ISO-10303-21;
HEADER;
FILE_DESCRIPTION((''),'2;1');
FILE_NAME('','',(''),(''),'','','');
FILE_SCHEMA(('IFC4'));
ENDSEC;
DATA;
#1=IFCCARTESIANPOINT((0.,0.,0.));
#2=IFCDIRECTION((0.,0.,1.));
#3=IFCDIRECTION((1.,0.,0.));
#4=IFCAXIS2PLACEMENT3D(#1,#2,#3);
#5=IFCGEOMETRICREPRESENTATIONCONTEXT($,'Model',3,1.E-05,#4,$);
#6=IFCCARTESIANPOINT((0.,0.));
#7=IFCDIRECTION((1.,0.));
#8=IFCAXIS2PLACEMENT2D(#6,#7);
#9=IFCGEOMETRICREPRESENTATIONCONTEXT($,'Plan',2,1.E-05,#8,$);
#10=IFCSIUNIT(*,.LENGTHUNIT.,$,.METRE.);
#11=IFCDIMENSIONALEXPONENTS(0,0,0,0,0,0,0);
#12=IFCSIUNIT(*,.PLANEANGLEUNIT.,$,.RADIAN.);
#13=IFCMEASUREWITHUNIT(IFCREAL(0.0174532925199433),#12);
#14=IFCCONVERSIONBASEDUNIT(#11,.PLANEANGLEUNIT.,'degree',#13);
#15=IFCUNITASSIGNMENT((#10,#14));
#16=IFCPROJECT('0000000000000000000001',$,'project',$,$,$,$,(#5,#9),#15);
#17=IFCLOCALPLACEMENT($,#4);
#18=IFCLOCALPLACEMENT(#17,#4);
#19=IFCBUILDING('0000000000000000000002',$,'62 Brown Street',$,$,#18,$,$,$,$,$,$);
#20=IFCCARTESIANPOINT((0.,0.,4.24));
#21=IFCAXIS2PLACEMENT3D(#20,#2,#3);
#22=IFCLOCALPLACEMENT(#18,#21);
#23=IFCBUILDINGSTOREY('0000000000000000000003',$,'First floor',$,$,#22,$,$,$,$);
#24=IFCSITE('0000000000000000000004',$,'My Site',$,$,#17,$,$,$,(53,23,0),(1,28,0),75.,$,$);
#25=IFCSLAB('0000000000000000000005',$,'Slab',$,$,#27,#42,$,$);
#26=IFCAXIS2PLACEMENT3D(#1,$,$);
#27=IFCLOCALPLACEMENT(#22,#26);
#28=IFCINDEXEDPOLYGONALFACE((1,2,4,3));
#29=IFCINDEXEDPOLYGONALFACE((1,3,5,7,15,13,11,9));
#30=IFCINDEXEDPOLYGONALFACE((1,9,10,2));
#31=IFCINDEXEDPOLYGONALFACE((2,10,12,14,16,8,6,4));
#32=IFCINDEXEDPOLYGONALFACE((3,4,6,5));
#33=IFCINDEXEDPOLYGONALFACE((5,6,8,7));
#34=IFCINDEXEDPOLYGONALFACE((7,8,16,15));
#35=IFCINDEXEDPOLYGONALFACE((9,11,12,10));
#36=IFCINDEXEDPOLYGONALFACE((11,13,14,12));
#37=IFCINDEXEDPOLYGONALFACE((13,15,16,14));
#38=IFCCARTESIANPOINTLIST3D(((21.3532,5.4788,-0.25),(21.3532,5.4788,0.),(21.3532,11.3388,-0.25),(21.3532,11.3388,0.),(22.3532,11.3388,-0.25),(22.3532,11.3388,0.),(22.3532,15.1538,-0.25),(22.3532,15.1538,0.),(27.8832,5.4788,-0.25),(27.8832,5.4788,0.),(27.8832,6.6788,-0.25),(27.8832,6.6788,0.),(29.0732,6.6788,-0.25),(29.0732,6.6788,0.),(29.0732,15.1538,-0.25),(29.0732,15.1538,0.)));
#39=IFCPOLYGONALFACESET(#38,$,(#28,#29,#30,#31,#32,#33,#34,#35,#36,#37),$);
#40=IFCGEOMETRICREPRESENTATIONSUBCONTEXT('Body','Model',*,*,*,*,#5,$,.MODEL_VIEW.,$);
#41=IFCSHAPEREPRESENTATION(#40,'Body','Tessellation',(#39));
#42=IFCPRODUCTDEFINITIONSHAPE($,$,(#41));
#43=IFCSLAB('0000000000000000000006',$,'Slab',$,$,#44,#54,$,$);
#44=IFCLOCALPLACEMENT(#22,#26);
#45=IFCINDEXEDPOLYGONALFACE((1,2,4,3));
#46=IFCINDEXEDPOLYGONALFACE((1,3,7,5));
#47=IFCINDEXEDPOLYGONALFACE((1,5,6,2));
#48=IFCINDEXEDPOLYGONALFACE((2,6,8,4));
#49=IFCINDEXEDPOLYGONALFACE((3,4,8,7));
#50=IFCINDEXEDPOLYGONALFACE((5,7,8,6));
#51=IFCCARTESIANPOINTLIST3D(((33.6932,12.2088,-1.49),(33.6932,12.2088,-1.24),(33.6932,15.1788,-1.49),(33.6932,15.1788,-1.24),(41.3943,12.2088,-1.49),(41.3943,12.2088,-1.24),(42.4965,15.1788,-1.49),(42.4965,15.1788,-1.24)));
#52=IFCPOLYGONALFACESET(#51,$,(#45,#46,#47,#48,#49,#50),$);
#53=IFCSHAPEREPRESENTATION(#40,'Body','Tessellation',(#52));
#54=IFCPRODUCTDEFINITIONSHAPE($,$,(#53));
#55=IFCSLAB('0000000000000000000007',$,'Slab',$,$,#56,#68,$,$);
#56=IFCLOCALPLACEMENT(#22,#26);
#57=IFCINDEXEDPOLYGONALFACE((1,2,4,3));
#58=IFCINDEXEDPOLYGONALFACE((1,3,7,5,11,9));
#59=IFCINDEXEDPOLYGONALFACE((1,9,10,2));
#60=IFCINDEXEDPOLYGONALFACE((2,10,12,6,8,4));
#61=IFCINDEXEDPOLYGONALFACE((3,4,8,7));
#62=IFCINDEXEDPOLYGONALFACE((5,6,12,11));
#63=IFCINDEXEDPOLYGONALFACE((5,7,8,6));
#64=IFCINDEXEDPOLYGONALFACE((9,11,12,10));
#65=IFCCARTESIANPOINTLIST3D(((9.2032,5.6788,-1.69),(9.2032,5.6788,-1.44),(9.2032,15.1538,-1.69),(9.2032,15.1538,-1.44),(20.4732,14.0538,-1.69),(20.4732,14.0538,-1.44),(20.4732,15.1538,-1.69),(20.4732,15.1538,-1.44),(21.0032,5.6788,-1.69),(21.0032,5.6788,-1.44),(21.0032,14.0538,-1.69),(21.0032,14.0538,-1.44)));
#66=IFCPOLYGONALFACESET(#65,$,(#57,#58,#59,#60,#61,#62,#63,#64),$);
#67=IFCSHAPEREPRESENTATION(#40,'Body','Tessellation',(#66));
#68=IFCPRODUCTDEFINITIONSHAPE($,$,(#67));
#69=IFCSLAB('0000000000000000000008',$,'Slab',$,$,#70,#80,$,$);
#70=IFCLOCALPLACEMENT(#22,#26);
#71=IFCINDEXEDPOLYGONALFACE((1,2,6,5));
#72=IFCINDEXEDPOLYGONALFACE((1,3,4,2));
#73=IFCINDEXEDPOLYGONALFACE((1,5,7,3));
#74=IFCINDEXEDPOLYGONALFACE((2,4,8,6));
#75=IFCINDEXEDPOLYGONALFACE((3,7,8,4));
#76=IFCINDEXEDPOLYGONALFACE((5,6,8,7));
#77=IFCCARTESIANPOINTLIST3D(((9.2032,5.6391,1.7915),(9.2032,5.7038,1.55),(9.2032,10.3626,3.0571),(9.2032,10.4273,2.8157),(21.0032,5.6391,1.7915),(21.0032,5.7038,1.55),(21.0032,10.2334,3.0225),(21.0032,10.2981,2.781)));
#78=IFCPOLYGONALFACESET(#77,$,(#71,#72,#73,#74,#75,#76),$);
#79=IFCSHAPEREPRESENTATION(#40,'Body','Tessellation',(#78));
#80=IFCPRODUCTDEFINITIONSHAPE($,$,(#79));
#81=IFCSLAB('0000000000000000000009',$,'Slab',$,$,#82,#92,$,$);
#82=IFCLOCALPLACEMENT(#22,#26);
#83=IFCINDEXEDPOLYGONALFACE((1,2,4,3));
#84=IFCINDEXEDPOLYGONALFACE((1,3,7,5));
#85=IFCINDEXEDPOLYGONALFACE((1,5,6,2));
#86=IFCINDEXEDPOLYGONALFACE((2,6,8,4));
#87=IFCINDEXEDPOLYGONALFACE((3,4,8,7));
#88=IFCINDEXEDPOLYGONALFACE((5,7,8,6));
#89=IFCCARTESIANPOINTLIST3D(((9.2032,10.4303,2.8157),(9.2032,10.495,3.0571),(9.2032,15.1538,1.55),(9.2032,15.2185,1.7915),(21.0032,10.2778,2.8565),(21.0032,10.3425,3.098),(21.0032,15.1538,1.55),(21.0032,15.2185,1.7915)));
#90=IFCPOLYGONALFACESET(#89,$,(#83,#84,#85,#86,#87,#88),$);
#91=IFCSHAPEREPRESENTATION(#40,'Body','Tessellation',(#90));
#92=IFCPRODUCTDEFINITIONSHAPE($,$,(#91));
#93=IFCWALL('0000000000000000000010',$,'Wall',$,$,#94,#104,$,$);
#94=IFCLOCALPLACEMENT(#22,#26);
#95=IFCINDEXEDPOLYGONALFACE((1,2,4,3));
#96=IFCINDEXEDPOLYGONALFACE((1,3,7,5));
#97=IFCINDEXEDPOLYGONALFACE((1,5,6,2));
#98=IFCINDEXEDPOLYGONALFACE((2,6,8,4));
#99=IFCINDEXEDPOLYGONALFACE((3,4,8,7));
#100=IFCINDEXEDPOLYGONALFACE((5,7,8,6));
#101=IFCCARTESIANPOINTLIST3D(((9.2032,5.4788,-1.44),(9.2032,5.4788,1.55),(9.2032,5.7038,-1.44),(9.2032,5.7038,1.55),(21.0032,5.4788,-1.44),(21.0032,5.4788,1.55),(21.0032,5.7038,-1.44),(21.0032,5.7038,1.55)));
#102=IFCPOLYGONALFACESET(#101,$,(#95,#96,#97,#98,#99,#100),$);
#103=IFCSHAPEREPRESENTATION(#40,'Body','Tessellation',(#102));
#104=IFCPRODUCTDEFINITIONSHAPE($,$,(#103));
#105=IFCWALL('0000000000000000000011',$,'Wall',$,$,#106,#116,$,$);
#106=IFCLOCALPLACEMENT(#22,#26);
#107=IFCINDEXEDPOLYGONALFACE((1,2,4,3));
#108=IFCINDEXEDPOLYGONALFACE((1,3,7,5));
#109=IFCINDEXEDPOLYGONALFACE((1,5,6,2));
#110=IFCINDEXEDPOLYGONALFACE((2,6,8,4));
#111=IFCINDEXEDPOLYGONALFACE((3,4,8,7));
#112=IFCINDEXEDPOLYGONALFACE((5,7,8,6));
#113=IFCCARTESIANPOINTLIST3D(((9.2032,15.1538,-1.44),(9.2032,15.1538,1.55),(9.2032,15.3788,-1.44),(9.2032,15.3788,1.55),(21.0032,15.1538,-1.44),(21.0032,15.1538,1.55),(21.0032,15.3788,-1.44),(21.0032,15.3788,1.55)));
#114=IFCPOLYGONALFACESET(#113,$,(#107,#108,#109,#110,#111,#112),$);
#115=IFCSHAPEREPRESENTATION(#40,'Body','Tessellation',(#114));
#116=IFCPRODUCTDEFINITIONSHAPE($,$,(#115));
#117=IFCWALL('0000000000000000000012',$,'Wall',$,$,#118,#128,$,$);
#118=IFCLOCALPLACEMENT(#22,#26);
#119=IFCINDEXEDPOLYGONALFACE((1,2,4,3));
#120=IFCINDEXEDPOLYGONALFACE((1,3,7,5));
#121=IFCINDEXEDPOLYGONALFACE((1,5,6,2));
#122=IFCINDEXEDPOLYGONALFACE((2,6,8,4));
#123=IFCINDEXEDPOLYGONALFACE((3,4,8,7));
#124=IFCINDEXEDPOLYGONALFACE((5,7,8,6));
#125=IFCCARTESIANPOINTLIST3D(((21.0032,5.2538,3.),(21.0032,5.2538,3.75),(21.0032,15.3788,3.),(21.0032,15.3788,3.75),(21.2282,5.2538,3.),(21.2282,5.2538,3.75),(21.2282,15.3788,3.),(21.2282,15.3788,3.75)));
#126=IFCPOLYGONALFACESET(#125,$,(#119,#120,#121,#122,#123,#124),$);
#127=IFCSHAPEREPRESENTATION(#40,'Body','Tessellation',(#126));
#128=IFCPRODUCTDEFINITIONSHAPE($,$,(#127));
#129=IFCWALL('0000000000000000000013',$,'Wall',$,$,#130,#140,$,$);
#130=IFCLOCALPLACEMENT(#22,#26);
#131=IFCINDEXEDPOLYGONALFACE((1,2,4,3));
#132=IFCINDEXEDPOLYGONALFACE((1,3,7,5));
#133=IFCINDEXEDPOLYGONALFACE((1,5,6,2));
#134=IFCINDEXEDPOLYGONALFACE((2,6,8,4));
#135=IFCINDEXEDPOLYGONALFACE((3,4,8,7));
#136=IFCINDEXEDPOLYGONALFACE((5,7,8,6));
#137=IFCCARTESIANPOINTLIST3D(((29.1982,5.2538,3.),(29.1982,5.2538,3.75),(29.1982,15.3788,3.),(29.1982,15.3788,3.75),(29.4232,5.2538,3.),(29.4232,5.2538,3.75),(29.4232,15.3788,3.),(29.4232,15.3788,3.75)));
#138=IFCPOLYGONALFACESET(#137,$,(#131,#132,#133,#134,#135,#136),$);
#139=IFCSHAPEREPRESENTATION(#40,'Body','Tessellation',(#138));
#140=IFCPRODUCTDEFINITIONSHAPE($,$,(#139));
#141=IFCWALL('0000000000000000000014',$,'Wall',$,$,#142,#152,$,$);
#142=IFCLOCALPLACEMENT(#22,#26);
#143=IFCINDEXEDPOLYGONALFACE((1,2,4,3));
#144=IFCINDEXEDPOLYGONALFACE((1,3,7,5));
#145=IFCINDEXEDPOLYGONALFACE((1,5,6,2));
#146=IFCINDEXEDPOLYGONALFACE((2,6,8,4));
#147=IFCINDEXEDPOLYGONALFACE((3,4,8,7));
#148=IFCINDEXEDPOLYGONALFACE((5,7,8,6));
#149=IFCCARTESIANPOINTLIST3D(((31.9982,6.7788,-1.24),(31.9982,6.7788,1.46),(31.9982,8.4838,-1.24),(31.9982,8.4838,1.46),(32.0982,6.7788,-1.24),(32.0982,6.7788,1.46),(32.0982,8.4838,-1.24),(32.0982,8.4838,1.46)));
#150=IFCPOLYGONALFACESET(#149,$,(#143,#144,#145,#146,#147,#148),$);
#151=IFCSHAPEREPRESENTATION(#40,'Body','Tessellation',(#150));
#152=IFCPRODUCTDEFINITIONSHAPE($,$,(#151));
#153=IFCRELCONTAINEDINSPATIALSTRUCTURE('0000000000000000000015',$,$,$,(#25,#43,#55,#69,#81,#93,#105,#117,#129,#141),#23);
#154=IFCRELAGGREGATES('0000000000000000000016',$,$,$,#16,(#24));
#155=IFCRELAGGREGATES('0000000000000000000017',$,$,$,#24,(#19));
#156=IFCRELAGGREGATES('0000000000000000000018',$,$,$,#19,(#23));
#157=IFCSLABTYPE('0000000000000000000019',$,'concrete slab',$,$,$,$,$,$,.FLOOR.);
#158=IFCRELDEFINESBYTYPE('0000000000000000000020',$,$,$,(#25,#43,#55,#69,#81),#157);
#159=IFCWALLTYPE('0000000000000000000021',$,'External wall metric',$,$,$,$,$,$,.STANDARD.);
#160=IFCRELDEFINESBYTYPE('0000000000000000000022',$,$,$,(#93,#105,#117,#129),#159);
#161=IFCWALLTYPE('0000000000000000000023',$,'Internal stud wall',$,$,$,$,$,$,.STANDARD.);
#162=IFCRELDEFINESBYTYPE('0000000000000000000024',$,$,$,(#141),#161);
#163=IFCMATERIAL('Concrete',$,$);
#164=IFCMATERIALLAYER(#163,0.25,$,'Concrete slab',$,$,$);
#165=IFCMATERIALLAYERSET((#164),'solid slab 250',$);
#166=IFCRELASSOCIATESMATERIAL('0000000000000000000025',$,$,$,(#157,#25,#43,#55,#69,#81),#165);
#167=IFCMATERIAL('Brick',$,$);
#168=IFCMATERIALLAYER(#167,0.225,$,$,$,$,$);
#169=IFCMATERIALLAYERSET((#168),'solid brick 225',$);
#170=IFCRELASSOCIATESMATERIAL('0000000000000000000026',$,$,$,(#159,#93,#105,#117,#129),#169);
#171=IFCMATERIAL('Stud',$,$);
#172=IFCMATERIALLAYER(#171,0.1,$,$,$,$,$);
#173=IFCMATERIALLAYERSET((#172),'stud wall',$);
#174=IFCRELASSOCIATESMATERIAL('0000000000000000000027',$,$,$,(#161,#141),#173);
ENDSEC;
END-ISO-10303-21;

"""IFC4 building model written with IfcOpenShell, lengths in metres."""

from ifc_helpers import new_model, entity, si_unit, converted_unit, frame, origin_with_axes, origin_2d_with_axis, place, context, subcontext, project, spatial, line, indexed_curve, outline, extrude, material, layer, layer_set, layer_usage, type_object, element, save


model = new_model("IFC4")

# Units and contexts
model_context = context("Model", 3, precision=1e-05, world=origin_with_axes())
plan_context = context("Plan", 2, precision=1e-05, world=origin_2d_with_axis())
body_context_1 = subcontext(model_context, "Body", "Model", "MODEL_VIEW")
ifc_project = project(units=[si_unit("LENGTHUNIT", "METRE"), converted_unit("PLANEANGLEUNIT", "degree", entity("IfcReal", 0.0174532925199433), si_unit("PLANEANGLEUNIT", "RADIAN"), dimensions=[0, 0, 0, 0, 0, 0, 0])], contexts=[model_context, plan_context])

# Site, building, storey
site_placement = place(None, origin_with_axes())
site = spatial("IfcSite", under=ifc_project, at=site_placement, Name="My Site", RefLatitude=(53, 23, 0), RefLongitude=(1, 28, 0), RefElevation=75.0)
building_placement = place(site_placement, origin_with_axes())
building = spatial("IfcBuilding", under=site, at=building_placement, Name="62 Brown Street")
storey_placement = place(building_placement, frame((0.0, 0.0, 4.24), z_axis=(0.0, 0.0, 1.0), x_axis=(1.0, 0.0, 0.0)))
storey = spatial("IfcBuildingStorey", under=building, at=storey_placement, Name="First floor")

# Slabs
ifc_material_1 = material(Name="Concrete")
ifc_layer_1 = layer(ifc_material_1, 0.25, Name="Concrete slab")
ifc_layer_set_1 = layer_set([ifc_layer_1], Name="solid slab 250")
ifc_layer_usage_1 = layer_usage(ifc_layer_set_1, "AXIS3", "POSITIVE", 0.0)
slab_type = type_object("IfcSlabType", Name="concrete slab", PredefinedType="FLOOR", material=ifc_layer_set_1)
slab_1_placement = place(storey_placement, frame((21.3532, 5.4788, -0.25), z_axis=(0.0, 0.0, 1.0), x_axis=(1.0, 0.0, 0.0)))
element("IfcSlab", 1, at=slab_1_placement, inside=storey, type_object=slab_type, material=ifc_layer_usage_1, Name="Slab", context=body_context_1, shape_type="SweptSolid", body=[
    extrude(outline(indexed_curve([(0.0, 5.86), (0.0, 0.0), (6.53, 0.0), (6.53, 1.2), (7.72, 1.2), (7.72, 9.675), (1.0, 9.675), (1.0, 5.86)], segments=[line(3, 2), line(2, 1), line(1, 8), line(8, 7), line(7, 6), line(6, 5), line(5, 4), line(4, 3)], self_intersect=False)), None, (0.0, 0.0, 1.0), 0.25),
])
ifc_layer_usage_2 = layer_usage(ifc_layer_set_1, "AXIS3", "POSITIVE", 0.0)
slab_2_placement = place(storey_placement, frame((33.6932, 12.2088, -1.49), z_axis=(0.0, 0.0, 1.0), x_axis=(1.0, 0.0, 0.0)))
element("IfcSlab", 2, at=slab_2_placement, inside=storey, type_object=slab_type, material=ifc_layer_usage_2, Name="Slab", context=body_context_1, shape_type="SweptSolid", body=[
    extrude(outline(indexed_curve([(8.8033, 2.97), (7.7011, 0.0), (0.0, 0.0), (0.0, 2.97)], segments=[line(4, 1), line(1, 2), line(2, 3), line(3, 4)], self_intersect=False)), None, (0.0, 0.0, 1.0), 0.25),
])
ifc_layer_usage_3 = layer_usage(ifc_layer_set_1, "AXIS3", "POSITIVE", 0.0)
slab_3_placement = place(storey_placement, frame((9.2032, 5.6788, -1.69), z_axis=(0.0, 0.0, 1.0), x_axis=(1.0, 0.0, 0.0)))
element("IfcSlab", 3, at=slab_3_placement, inside=storey, type_object=slab_type, material=ifc_layer_usage_3, Name="Slab", context=body_context_1, shape_type="SweptSolid", body=[
    extrude(outline(indexed_curve([(11.27, 9.475), (11.8, 0.0), (0.0, 0.0), (0.0, 9.475), (11.8, 8.375), (11.27, 8.375)], segments=[line(6, 1), line(1, 4), line(4, 3), line(3, 2), line(2, 5), line(5, 6)], self_intersect=False)), None, (0.0, 0.0, 1.0), 0.25),
])
ifc_layer_usage_4 = layer_usage(ifc_layer_set_1, "AXIS3", "POSITIVE", 0.0)
slab_4_placement = place(storey_placement, frame((9.2032, 5.7038, 1.55), z_axis=(0.0, -0.258819, 0.965926), x_axis=(1.0, 0.0, 0.0)))
element("IfcSlab", 4, at=slab_4_placement, inside=storey, type_object=slab_type, material=ifc_layer_usage_4, Name="Slab", context=body_context_1, shape_type="SweptSolid", body=[
    extrude(outline(indexed_curve([(0.0, 4.8901), (0.0, 0.0), (11.8, 0.0), (11.8, 4.7563)], segments=[line(3, 2), line(2, 1), line(1, 4), line(4, 3)], self_intersect=False)), None, (0.0, 0.0, 1.0), 0.25),
])
ifc_layer_usage_5 = layer_usage(ifc_layer_set_1, "AXIS3", "POSITIVE", 0.0)
slab_5_placement = place(storey_placement, frame((21.0032, 15.1538, 1.55), z_axis=(0.0, 0.258819, 0.965926), x_axis=(-1.0, 0.0, 0.0)))
element("IfcSlab", 5, at=slab_5_placement, inside=storey, type_object=slab_type, material=ifc_layer_usage_5, Name="Slab", context=body_context_1, shape_type="SweptSolid", body=[
    extrude(outline(indexed_curve([(0.0, 0.0), (11.8, 0.0), (11.8, 4.8901), (0.0, 5.048)], segments=[line(4, 1), line(1, 2), line(2, 3), line(3, 4)], self_intersect=False)), None, (0.0, 0.0, 1.0), 0.25),
])

# Walls
ifc_material_2 = material(Name="Brick")
ifc_layer_2 = layer(ifc_material_2, 0.225)
ifc_layer_set_2 = layer_set([ifc_layer_2], Name="solid brick 225")
ifc_layer_usage_6 = layer_usage(ifc_layer_set_2, "AXIS2", "POSITIVE", 0.0)
wall_type_1 = type_object("IfcWallType", Name="External wall metric", PredefinedType="STANDARD", material=ifc_layer_set_2)
wall_1_placement = place(storey_placement, frame((9.2032, 5.4788, -1.44), z_axis=(0.0, 0.0, 1.0), x_axis=(1.0, 0.0, 0.0)))
element("IfcWall", 6, at=wall_1_placement, inside=storey, type_object=wall_type_1, material=ifc_layer_usage_6, Name="Wall", context=body_context_1, shape_type="SweptSolid", body=[
    extrude(outline(indexed_curve([(0.0, 0.0), (0.0, 0.225), (11.8, 0.225), (11.8, 0.0), (0.0, 0.0)], self_intersect=False)), origin_with_axes(), (0.0, 0.0, 1.0), 2.99),
])
ifc_layer_usage_7 = layer_usage(ifc_layer_set_2, "AXIS2", "POSITIVE", 0.0)
wall_2_placement = place(storey_placement, frame((21.0032, 15.3788, -1.44), z_axis=(0.0, 0.0, 1.0), x_axis=(-1.0, 0.0, 0.0)))
element("IfcWall", 7, at=wall_2_placement, inside=storey, type_object=wall_type_1, material=ifc_layer_usage_7, Name="Wall", context=body_context_1, shape_type="SweptSolid", body=[
    extrude(outline(indexed_curve([(0.0, 0.0), (0.0, 0.225), (11.8, 0.225), (11.8, 0.0), (0.0, 0.0)], self_intersect=False)), origin_with_axes(), (0.0, 0.0, 1.0), 2.99),
])
ifc_layer_usage_8 = layer_usage(ifc_layer_set_2, "AXIS2", "POSITIVE", 0.0)
wall_3_placement = place(storey_placement, frame((21.0032, 15.3788, 3.0), z_axis=(0.0, 0.0, 1.0), x_axis=(0.0, -1.0, 0.0)))
element("IfcWall", 8, at=wall_3_placement, inside=storey, type_object=wall_type_1, material=ifc_layer_usage_8, Name="Wall", context=body_context_1, shape_type="SweptSolid", body=[
    extrude(outline(indexed_curve([(0.0, 0.0), (0.0, 0.225), (10.125, 0.225), (10.125, 0.0), (0.0, 0.0)], self_intersect=False)), origin_with_axes(), (0.0, 0.0, 1.0), 0.75),
])
ifc_layer_usage_9 = layer_usage(ifc_layer_set_2, "AXIS2", "POSITIVE", 0.0)
wall_4_placement = place(storey_placement, frame((29.4232, 5.2538, 3.0), z_axis=(0.0, 0.0, 1.0), x_axis=(0.0, 1.0, 0.0)))
element("IfcWall", 9, at=wall_4_placement, inside=storey, type_object=wall_type_1, material=ifc_layer_usage_9, Name="Wall", context=body_context_1, shape_type="SweptSolid", body=[
    extrude(outline(indexed_curve([(0.0, 0.0), (0.0, 0.225), (10.125, 0.225), (10.125, 0.0), (0.0, 0.0)], self_intersect=False)), origin_with_axes(), (0.0, 0.0, 1.0), 0.75),
])
ifc_material_3 = material(Name="Stud")
ifc_layer_3 = layer(ifc_material_3, 0.1)
ifc_layer_set_3 = layer_set([ifc_layer_3], Name="stud wall")
ifc_layer_usage_10 = layer_usage(ifc_layer_set_3, "AXIS2", "POSITIVE", 0.0)
wall_type_2 = type_object("IfcWallType", Name="Internal stud wall", PredefinedType="STANDARD", material=ifc_layer_set_3)
wall_5_placement = place(storey_placement, frame((32.0982, 6.7788, -1.24), z_axis=(0.0, 0.0, 1.0), x_axis=(0.000001, 1.0, 0.0)))
element("IfcWall", 10, at=wall_5_placement, inside=storey, type_object=wall_type_2, material=ifc_layer_usage_10, Name="Wall", context=body_context_1, shape_type="SweptSolid", body=[
    extrude(outline(indexed_curve([(0.0, 0.0), (0.0, 0.1), (1.705, 0.1), (1.705, 0.0), (0.0, 0.0)], self_intersect=False)), origin_with_axes(), (0.0, 0.0, 1.0), 2.7),
])

save(model, "model.ifc")
